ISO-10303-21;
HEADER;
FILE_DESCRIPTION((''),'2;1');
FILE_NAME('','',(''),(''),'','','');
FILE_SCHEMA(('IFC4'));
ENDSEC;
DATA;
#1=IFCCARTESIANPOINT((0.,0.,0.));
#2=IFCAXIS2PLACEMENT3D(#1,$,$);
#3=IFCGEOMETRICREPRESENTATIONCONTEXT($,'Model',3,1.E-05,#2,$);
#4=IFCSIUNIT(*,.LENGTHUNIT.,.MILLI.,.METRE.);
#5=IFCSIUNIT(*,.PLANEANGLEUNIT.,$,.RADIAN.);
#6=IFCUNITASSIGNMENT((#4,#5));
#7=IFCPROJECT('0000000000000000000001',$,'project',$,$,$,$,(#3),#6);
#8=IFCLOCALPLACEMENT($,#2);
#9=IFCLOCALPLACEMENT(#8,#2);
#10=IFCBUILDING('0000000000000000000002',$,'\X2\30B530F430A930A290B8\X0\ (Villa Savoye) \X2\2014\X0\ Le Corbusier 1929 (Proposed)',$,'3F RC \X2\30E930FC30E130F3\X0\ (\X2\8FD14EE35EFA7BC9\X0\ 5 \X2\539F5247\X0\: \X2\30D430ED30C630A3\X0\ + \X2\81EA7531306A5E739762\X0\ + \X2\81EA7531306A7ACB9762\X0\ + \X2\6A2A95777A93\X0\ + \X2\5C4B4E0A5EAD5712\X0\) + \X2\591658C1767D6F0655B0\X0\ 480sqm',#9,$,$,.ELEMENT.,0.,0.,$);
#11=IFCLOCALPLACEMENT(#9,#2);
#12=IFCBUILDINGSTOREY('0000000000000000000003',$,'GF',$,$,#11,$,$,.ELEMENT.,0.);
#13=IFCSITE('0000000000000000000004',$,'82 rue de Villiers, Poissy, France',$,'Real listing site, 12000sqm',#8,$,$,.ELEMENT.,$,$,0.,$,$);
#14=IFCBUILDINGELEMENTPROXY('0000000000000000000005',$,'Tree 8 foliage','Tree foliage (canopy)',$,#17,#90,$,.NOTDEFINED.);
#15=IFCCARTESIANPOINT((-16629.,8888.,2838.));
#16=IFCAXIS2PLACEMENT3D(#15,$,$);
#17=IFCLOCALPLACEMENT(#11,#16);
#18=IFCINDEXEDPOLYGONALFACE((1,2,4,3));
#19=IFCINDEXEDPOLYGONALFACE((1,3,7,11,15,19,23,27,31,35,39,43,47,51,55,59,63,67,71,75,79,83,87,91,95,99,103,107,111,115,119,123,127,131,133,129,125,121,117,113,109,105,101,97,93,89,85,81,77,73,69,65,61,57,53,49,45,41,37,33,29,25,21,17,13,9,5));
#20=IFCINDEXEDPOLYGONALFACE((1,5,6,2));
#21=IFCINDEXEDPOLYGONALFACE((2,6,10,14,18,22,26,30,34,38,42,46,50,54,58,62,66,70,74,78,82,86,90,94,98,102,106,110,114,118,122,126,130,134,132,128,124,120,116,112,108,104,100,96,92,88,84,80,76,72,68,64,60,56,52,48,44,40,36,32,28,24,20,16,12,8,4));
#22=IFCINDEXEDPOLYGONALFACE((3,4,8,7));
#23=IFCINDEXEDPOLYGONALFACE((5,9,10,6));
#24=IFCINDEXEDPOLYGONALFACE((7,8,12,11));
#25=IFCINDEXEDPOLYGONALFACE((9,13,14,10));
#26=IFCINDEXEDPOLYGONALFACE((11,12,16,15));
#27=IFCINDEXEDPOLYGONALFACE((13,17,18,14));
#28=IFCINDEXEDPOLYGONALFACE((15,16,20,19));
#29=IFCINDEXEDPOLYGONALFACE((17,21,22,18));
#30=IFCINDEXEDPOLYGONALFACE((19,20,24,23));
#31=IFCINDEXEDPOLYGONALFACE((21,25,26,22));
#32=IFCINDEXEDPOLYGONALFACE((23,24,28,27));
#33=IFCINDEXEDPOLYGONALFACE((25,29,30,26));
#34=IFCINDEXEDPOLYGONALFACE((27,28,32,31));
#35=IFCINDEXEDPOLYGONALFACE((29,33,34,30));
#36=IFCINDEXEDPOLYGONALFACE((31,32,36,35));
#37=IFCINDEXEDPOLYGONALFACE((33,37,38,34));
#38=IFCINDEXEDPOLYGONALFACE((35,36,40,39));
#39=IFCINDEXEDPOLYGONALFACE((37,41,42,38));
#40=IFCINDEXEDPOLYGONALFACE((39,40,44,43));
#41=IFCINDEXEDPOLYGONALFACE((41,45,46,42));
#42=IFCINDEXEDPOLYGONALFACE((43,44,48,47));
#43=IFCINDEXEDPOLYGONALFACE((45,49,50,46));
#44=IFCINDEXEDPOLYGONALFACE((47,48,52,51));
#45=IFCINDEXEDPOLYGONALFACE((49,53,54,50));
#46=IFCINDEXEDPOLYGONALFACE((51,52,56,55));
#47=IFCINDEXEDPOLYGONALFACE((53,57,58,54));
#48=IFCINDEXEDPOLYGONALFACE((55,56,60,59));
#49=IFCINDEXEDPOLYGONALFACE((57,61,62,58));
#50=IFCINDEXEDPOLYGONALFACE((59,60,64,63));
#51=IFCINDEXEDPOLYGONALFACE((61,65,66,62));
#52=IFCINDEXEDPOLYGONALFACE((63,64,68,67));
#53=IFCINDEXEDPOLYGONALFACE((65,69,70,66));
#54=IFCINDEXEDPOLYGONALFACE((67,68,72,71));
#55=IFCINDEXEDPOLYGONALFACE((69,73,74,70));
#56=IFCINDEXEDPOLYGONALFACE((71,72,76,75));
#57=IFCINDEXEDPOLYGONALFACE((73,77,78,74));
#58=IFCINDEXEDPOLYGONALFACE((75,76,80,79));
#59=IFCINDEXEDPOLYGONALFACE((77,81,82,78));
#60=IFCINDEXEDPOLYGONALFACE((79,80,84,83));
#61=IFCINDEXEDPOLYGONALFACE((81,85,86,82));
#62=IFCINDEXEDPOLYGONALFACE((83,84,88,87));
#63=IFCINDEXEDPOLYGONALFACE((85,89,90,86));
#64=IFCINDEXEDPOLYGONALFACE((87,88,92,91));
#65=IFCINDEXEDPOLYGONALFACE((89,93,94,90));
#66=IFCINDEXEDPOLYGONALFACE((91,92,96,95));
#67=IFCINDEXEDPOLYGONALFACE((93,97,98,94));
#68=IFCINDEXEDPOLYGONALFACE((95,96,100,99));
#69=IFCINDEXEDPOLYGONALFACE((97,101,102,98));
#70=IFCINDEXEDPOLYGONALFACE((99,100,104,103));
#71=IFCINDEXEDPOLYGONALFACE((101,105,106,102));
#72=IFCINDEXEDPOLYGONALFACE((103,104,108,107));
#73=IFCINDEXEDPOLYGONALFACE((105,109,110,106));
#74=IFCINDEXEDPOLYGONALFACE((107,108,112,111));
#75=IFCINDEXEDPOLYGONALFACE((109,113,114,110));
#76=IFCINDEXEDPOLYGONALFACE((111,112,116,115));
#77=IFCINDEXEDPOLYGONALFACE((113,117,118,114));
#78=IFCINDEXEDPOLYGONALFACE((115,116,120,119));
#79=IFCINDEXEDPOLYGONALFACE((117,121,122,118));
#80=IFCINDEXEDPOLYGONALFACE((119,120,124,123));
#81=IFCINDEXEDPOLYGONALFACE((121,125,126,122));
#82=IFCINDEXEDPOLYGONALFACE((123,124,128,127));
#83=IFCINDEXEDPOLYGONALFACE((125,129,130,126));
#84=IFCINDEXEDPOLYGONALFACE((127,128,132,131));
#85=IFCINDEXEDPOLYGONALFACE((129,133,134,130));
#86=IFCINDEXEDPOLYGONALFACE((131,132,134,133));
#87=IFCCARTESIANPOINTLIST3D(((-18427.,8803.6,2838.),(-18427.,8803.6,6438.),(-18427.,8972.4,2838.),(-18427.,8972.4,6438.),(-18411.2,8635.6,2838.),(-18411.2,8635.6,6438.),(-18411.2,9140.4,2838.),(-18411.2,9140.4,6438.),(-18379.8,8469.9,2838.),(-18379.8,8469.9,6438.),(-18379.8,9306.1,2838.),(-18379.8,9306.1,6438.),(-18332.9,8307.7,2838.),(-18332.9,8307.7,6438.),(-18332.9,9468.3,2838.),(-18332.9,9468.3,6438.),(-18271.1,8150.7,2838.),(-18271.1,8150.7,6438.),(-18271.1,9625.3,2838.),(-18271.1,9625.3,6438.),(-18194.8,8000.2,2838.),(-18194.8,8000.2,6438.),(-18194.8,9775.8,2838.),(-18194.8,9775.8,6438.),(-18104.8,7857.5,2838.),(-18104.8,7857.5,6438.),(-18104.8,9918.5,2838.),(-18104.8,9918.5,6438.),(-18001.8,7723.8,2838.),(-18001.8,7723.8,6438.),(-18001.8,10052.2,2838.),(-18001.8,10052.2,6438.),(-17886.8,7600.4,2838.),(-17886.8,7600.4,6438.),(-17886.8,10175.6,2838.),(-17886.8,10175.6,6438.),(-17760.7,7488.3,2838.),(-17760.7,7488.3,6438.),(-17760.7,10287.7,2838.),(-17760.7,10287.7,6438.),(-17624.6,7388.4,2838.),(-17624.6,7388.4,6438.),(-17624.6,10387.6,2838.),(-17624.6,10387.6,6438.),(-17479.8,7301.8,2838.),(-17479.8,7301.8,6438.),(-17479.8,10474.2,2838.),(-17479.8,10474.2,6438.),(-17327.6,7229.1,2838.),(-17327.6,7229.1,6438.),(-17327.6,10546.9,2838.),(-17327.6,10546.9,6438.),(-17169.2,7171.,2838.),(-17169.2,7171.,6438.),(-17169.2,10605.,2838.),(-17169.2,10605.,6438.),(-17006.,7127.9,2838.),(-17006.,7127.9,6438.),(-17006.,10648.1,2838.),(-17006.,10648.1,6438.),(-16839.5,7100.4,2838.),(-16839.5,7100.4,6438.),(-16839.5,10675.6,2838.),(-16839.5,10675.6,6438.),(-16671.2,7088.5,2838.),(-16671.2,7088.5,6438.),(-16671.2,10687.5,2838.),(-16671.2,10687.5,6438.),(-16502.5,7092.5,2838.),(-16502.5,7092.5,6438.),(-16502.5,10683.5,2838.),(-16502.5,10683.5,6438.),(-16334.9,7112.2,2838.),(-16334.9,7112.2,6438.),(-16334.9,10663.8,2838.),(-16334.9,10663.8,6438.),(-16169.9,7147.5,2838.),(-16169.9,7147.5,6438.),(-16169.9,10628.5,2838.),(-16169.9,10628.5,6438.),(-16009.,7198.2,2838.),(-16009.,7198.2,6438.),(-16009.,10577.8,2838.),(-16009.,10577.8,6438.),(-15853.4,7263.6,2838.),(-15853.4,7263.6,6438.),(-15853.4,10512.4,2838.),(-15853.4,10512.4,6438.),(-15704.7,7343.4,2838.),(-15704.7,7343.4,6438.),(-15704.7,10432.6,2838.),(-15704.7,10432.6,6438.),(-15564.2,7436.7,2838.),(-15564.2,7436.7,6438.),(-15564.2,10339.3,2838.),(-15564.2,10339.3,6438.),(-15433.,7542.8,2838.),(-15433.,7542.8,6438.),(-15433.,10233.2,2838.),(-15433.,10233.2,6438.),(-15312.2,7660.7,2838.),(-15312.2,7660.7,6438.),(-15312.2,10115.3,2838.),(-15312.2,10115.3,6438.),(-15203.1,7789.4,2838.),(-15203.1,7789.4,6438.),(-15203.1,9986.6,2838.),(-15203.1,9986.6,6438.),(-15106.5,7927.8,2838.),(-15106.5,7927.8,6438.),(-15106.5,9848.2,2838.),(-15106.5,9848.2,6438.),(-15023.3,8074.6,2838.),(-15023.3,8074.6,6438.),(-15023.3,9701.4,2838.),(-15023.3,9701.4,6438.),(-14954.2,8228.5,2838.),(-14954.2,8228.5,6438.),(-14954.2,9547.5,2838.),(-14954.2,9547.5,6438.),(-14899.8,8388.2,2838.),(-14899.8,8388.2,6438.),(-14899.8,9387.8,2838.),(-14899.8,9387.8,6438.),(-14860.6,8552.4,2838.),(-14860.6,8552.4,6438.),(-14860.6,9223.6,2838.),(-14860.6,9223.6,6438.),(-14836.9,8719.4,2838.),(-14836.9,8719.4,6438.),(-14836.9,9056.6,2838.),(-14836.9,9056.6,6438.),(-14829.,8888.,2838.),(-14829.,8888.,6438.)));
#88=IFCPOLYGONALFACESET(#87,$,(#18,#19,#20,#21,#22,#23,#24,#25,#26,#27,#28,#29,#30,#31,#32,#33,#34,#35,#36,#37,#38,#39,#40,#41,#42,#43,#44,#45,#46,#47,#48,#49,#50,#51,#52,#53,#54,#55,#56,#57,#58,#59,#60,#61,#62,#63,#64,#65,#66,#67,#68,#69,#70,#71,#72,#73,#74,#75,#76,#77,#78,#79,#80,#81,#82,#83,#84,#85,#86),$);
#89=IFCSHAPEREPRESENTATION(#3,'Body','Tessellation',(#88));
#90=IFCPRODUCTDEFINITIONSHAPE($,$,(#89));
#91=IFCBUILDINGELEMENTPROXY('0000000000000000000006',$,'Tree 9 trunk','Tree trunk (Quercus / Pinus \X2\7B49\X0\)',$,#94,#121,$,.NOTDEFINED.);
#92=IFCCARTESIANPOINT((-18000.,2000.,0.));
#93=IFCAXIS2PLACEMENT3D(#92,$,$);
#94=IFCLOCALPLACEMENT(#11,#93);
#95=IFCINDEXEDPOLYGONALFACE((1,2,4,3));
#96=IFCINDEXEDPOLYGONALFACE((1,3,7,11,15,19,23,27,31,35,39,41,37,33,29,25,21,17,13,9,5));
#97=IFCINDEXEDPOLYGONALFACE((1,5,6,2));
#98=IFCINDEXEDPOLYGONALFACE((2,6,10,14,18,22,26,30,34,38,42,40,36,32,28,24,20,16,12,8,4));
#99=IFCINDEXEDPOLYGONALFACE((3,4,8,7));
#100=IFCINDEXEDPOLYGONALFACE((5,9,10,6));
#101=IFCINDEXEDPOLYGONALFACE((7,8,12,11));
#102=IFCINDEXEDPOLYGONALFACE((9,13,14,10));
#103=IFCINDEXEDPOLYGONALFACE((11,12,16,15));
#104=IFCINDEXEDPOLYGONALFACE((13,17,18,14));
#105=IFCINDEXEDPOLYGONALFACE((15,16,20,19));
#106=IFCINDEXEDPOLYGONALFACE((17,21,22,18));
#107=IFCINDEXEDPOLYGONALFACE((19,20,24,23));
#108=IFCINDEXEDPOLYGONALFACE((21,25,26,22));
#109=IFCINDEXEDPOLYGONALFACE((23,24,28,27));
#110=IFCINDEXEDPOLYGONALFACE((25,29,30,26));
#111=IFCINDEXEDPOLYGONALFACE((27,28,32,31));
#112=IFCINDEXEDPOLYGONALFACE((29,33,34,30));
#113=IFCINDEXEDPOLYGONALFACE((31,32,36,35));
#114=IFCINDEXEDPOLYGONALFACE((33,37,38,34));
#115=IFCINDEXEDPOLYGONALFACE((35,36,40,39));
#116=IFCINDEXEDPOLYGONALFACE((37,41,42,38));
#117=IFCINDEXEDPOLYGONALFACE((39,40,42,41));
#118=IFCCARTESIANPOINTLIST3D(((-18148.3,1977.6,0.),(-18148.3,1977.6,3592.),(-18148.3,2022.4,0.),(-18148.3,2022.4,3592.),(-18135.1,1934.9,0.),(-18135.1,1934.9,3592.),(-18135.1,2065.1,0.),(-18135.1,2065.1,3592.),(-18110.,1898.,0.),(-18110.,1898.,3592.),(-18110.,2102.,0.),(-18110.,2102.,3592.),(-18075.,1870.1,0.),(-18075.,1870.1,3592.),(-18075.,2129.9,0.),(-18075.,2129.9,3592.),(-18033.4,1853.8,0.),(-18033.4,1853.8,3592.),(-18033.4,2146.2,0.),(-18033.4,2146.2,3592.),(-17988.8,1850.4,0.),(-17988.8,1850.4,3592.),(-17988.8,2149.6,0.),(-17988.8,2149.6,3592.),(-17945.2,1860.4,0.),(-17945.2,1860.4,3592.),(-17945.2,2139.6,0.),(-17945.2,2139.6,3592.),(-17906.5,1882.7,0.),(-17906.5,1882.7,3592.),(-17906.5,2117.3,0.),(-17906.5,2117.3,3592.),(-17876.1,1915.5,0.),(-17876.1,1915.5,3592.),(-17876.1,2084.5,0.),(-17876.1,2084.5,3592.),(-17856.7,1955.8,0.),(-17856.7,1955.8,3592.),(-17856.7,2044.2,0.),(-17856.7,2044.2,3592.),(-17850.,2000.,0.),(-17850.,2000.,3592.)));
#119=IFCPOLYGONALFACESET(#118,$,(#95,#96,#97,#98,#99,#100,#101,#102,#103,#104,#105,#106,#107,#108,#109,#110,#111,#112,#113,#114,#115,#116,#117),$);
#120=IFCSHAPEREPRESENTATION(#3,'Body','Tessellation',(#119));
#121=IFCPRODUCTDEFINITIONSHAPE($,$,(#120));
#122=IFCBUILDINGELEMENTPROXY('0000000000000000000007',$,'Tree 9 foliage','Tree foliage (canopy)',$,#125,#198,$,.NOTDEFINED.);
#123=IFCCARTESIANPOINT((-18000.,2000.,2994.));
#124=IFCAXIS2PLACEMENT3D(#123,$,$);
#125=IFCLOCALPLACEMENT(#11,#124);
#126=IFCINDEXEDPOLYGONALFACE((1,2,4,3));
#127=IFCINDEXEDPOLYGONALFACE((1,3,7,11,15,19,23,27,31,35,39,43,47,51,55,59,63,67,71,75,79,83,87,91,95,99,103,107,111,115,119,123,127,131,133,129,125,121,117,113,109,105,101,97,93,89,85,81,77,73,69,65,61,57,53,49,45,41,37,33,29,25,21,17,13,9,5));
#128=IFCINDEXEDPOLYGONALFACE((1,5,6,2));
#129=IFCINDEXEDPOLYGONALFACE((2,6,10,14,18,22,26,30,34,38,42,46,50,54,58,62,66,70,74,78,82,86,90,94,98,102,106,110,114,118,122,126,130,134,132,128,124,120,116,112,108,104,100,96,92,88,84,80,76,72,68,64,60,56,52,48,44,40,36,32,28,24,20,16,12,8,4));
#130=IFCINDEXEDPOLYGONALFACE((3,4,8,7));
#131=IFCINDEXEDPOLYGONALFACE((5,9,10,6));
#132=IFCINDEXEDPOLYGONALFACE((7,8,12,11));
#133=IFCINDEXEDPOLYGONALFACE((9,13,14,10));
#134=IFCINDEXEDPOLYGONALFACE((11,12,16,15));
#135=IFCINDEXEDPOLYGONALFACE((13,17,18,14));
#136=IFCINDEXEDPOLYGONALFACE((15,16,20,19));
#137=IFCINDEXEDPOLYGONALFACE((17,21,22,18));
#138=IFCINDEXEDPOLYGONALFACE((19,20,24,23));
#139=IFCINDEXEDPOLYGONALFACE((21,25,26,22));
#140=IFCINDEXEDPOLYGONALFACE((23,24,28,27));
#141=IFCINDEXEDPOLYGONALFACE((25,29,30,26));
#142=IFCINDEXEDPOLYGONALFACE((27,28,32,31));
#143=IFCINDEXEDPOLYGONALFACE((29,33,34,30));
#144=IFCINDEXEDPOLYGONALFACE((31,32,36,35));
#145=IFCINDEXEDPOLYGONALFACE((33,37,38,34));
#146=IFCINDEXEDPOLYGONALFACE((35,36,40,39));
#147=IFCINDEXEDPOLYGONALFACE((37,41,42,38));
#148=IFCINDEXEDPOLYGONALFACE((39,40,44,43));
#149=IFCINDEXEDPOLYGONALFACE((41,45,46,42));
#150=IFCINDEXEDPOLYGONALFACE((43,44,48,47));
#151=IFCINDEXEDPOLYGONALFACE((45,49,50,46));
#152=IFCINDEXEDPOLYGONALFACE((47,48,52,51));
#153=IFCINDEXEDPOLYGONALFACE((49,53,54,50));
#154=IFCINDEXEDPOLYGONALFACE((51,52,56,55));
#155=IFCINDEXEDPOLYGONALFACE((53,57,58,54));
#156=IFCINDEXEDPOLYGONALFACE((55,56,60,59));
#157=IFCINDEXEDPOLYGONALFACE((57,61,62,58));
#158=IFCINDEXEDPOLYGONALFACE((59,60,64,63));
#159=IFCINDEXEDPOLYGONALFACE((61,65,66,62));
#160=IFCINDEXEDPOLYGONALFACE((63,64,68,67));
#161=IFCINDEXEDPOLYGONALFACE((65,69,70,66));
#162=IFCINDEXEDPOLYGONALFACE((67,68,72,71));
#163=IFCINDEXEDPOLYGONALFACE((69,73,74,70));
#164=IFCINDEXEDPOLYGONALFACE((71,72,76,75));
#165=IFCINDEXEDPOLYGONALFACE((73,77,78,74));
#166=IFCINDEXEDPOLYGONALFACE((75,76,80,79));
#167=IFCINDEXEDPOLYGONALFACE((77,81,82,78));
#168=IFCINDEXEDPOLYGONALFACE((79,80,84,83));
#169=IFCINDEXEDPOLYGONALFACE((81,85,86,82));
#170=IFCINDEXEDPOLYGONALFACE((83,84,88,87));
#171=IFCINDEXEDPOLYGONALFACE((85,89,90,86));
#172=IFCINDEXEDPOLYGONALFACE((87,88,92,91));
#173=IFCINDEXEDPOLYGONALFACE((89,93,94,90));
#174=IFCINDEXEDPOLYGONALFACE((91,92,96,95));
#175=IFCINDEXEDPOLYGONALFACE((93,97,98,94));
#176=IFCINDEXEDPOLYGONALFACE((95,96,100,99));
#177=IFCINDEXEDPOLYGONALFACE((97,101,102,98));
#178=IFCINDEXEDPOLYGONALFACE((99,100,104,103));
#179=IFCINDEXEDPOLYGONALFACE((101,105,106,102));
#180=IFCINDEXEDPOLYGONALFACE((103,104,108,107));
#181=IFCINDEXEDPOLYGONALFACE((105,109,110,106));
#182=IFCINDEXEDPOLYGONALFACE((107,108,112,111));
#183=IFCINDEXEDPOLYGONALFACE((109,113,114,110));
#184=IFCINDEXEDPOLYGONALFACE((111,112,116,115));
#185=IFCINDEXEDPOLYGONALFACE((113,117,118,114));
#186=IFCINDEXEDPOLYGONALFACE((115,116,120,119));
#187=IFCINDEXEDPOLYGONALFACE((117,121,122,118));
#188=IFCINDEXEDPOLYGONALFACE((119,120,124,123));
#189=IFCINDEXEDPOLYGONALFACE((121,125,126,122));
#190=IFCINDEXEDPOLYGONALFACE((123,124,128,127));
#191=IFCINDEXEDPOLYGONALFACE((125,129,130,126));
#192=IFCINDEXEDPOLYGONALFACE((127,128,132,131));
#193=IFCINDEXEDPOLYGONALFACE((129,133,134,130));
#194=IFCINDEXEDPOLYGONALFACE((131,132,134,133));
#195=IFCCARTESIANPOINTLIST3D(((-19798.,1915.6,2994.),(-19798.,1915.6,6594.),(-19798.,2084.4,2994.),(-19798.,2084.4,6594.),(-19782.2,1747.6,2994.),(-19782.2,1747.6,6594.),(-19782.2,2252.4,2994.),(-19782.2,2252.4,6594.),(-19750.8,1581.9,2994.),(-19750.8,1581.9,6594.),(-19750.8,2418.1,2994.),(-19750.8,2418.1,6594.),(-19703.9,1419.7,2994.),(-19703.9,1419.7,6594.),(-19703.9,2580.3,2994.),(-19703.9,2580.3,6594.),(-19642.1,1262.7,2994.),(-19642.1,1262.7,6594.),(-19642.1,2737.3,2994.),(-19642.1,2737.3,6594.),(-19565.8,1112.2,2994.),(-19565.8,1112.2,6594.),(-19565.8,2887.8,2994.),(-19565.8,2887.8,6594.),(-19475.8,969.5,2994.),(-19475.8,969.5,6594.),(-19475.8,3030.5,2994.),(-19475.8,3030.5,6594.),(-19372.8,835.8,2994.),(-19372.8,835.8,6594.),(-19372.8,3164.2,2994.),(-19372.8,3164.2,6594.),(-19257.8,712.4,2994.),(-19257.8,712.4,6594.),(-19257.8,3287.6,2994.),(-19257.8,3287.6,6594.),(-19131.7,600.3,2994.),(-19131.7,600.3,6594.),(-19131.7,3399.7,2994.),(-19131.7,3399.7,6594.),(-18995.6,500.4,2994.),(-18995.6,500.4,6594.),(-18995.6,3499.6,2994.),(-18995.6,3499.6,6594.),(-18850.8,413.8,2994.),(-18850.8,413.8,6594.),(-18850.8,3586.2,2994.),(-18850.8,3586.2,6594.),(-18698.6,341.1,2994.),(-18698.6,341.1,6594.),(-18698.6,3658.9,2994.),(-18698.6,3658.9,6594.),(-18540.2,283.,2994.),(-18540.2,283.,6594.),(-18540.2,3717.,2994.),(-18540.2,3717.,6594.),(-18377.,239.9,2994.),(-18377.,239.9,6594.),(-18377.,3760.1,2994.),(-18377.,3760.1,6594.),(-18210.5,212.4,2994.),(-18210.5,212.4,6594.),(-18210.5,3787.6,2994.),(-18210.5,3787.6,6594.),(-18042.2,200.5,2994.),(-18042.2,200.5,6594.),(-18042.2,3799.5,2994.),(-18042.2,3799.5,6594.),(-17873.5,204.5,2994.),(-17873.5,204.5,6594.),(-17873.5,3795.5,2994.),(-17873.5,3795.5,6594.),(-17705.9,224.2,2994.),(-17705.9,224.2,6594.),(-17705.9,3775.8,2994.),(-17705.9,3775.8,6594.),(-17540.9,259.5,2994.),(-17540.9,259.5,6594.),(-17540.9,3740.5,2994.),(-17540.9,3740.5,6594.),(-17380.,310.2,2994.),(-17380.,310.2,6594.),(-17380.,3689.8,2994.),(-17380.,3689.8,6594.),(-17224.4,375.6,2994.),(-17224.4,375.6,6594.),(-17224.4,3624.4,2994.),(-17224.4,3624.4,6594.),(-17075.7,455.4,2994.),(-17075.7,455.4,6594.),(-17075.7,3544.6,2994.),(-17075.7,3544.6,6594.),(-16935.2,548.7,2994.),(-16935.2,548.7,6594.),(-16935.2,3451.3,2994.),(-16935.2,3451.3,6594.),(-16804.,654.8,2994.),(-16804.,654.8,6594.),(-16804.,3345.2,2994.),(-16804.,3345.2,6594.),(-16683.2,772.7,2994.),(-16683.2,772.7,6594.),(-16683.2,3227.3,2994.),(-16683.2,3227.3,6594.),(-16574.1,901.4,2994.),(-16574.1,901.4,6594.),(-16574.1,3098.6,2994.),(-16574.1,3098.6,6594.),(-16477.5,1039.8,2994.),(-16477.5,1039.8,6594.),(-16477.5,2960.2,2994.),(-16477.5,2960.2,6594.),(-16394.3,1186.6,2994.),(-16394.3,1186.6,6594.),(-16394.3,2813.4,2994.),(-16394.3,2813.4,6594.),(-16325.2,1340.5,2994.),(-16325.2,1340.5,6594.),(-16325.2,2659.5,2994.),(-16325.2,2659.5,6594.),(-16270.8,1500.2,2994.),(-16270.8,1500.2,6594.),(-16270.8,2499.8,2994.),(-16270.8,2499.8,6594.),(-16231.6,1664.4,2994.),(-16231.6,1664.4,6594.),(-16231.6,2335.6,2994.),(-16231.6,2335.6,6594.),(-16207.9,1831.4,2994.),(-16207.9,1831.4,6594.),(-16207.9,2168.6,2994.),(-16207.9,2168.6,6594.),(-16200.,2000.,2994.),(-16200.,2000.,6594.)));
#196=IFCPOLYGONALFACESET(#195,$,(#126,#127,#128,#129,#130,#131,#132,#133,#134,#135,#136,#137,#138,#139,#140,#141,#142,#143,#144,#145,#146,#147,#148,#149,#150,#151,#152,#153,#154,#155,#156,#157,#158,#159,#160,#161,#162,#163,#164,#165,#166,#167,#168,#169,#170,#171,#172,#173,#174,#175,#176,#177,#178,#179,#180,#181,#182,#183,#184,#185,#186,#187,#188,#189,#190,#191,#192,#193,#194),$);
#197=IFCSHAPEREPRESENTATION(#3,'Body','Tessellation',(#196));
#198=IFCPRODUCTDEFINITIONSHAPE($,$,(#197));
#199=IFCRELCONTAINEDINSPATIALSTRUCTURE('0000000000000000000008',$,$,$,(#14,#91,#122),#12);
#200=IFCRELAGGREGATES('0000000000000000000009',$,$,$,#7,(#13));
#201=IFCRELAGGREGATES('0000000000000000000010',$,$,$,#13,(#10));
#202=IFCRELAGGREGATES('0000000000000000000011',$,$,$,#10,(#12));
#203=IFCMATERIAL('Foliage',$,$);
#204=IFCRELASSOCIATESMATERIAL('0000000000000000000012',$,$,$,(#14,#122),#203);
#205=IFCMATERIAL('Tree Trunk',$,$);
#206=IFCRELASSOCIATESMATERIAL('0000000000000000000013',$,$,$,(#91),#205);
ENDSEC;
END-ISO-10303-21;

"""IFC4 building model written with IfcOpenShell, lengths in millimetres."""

from ifc_helpers import new_model, si_unit, frame, origin, origin_2d, place, context, project, spatial, circle, extrude, material, element, save


model = new_model("IFC4")

# Units and contexts
model_context = context("Model", 3, precision=1e-05, world=origin())
ifc_project = project(units=[si_unit("LENGTHUNIT", "METRE", prefix="MILLI"), si_unit("PLANEANGLEUNIT", "RADIAN")], contexts=[model_context])

# Site, building, storey
site_placement = place(None, origin())
site = spatial("IfcSite", under=ifc_project, at=site_placement, Name="82 rue de Villiers, Poissy, France", ObjectType="Real listing site, 12000sqm", CompositionType="ELEMENT", RefElevation=0.0)
building_placement = place(site_placement, origin())
building = spatial("IfcBuilding", under=site, at=building_placement, Name="サヴォア邸 (Villa Savoye) — Le Corbusier 1929 (Proposed)", ObjectType="3F RC ラーメン (近代建築 5 原則: ピロティ + 自由な平面 + 自由な立面 + 横長窓 + 屋上庭園) + 外壁白漆喰 480sqm", CompositionType="ELEMENT", ElevationOfRefHeight=0.0, ElevationOfTerrain=0.0)
storey_placement = place(building_placement, origin())
storey = spatial("IfcBuildingStorey", under=building, at=storey_placement, Name="GF", CompositionType="ELEMENT", Elevation=0.0)

# Building element proxies
ifc_material_1 = material(Name="Tree Trunk")
ifc_material_2 = material(Name="Foliage")
proxy_1_placement = place(storey_placement, frame((-16629.0, 8888.0, 2838.0)))
element("IfcBuildingElementProxy", 1, at=proxy_1_placement, inside=storey, material=ifc_material_2, Name="Tree 8 foliage", Description="Tree foliage (canopy)", PredefinedType="NOTDEFINED", context=model_context, shape_type="SweptSolid", body=[
    extrude(circle(Radius=1800.0, at=origin_2d()), frame((-16629.0, 8888.0, 2838.0)), (0.0, 0.0, 1.0), 3600.0),
])
proxy_2_placement = place(storey_placement, frame((-18000.0, 2000.0, 0.0)))
element("IfcBuildingElementProxy", 2, at=proxy_2_placement, inside=storey, material=ifc_material_1, Name="Tree 9 trunk", Description="Tree trunk (Quercus / Pinus 等)", PredefinedType="NOTDEFINED", context=model_context, shape_type="SweptSolid", body=[
    extrude(circle(Radius=150.0, at=origin_2d()), frame((-18000.0, 2000.0, 0.0)), (0.0, 0.0, 1.0), 3592.0),
])
proxy_3_placement = place(storey_placement, frame((-18000.0, 2000.0, 2994.0)))
element("IfcBuildingElementProxy", 3, at=proxy_3_placement, inside=storey, material=ifc_material_2, Name="Tree 9 foliage", Description="Tree foliage (canopy)", PredefinedType="NOTDEFINED", context=model_context, shape_type="SweptSolid", body=[
    extrude(circle(Radius=1800.0, at=origin_2d()), frame((-18000.0, 2000.0, 2994.0)), (0.0, 0.0, 1.0), 3600.0),
])

save(model, "model.ifc")
